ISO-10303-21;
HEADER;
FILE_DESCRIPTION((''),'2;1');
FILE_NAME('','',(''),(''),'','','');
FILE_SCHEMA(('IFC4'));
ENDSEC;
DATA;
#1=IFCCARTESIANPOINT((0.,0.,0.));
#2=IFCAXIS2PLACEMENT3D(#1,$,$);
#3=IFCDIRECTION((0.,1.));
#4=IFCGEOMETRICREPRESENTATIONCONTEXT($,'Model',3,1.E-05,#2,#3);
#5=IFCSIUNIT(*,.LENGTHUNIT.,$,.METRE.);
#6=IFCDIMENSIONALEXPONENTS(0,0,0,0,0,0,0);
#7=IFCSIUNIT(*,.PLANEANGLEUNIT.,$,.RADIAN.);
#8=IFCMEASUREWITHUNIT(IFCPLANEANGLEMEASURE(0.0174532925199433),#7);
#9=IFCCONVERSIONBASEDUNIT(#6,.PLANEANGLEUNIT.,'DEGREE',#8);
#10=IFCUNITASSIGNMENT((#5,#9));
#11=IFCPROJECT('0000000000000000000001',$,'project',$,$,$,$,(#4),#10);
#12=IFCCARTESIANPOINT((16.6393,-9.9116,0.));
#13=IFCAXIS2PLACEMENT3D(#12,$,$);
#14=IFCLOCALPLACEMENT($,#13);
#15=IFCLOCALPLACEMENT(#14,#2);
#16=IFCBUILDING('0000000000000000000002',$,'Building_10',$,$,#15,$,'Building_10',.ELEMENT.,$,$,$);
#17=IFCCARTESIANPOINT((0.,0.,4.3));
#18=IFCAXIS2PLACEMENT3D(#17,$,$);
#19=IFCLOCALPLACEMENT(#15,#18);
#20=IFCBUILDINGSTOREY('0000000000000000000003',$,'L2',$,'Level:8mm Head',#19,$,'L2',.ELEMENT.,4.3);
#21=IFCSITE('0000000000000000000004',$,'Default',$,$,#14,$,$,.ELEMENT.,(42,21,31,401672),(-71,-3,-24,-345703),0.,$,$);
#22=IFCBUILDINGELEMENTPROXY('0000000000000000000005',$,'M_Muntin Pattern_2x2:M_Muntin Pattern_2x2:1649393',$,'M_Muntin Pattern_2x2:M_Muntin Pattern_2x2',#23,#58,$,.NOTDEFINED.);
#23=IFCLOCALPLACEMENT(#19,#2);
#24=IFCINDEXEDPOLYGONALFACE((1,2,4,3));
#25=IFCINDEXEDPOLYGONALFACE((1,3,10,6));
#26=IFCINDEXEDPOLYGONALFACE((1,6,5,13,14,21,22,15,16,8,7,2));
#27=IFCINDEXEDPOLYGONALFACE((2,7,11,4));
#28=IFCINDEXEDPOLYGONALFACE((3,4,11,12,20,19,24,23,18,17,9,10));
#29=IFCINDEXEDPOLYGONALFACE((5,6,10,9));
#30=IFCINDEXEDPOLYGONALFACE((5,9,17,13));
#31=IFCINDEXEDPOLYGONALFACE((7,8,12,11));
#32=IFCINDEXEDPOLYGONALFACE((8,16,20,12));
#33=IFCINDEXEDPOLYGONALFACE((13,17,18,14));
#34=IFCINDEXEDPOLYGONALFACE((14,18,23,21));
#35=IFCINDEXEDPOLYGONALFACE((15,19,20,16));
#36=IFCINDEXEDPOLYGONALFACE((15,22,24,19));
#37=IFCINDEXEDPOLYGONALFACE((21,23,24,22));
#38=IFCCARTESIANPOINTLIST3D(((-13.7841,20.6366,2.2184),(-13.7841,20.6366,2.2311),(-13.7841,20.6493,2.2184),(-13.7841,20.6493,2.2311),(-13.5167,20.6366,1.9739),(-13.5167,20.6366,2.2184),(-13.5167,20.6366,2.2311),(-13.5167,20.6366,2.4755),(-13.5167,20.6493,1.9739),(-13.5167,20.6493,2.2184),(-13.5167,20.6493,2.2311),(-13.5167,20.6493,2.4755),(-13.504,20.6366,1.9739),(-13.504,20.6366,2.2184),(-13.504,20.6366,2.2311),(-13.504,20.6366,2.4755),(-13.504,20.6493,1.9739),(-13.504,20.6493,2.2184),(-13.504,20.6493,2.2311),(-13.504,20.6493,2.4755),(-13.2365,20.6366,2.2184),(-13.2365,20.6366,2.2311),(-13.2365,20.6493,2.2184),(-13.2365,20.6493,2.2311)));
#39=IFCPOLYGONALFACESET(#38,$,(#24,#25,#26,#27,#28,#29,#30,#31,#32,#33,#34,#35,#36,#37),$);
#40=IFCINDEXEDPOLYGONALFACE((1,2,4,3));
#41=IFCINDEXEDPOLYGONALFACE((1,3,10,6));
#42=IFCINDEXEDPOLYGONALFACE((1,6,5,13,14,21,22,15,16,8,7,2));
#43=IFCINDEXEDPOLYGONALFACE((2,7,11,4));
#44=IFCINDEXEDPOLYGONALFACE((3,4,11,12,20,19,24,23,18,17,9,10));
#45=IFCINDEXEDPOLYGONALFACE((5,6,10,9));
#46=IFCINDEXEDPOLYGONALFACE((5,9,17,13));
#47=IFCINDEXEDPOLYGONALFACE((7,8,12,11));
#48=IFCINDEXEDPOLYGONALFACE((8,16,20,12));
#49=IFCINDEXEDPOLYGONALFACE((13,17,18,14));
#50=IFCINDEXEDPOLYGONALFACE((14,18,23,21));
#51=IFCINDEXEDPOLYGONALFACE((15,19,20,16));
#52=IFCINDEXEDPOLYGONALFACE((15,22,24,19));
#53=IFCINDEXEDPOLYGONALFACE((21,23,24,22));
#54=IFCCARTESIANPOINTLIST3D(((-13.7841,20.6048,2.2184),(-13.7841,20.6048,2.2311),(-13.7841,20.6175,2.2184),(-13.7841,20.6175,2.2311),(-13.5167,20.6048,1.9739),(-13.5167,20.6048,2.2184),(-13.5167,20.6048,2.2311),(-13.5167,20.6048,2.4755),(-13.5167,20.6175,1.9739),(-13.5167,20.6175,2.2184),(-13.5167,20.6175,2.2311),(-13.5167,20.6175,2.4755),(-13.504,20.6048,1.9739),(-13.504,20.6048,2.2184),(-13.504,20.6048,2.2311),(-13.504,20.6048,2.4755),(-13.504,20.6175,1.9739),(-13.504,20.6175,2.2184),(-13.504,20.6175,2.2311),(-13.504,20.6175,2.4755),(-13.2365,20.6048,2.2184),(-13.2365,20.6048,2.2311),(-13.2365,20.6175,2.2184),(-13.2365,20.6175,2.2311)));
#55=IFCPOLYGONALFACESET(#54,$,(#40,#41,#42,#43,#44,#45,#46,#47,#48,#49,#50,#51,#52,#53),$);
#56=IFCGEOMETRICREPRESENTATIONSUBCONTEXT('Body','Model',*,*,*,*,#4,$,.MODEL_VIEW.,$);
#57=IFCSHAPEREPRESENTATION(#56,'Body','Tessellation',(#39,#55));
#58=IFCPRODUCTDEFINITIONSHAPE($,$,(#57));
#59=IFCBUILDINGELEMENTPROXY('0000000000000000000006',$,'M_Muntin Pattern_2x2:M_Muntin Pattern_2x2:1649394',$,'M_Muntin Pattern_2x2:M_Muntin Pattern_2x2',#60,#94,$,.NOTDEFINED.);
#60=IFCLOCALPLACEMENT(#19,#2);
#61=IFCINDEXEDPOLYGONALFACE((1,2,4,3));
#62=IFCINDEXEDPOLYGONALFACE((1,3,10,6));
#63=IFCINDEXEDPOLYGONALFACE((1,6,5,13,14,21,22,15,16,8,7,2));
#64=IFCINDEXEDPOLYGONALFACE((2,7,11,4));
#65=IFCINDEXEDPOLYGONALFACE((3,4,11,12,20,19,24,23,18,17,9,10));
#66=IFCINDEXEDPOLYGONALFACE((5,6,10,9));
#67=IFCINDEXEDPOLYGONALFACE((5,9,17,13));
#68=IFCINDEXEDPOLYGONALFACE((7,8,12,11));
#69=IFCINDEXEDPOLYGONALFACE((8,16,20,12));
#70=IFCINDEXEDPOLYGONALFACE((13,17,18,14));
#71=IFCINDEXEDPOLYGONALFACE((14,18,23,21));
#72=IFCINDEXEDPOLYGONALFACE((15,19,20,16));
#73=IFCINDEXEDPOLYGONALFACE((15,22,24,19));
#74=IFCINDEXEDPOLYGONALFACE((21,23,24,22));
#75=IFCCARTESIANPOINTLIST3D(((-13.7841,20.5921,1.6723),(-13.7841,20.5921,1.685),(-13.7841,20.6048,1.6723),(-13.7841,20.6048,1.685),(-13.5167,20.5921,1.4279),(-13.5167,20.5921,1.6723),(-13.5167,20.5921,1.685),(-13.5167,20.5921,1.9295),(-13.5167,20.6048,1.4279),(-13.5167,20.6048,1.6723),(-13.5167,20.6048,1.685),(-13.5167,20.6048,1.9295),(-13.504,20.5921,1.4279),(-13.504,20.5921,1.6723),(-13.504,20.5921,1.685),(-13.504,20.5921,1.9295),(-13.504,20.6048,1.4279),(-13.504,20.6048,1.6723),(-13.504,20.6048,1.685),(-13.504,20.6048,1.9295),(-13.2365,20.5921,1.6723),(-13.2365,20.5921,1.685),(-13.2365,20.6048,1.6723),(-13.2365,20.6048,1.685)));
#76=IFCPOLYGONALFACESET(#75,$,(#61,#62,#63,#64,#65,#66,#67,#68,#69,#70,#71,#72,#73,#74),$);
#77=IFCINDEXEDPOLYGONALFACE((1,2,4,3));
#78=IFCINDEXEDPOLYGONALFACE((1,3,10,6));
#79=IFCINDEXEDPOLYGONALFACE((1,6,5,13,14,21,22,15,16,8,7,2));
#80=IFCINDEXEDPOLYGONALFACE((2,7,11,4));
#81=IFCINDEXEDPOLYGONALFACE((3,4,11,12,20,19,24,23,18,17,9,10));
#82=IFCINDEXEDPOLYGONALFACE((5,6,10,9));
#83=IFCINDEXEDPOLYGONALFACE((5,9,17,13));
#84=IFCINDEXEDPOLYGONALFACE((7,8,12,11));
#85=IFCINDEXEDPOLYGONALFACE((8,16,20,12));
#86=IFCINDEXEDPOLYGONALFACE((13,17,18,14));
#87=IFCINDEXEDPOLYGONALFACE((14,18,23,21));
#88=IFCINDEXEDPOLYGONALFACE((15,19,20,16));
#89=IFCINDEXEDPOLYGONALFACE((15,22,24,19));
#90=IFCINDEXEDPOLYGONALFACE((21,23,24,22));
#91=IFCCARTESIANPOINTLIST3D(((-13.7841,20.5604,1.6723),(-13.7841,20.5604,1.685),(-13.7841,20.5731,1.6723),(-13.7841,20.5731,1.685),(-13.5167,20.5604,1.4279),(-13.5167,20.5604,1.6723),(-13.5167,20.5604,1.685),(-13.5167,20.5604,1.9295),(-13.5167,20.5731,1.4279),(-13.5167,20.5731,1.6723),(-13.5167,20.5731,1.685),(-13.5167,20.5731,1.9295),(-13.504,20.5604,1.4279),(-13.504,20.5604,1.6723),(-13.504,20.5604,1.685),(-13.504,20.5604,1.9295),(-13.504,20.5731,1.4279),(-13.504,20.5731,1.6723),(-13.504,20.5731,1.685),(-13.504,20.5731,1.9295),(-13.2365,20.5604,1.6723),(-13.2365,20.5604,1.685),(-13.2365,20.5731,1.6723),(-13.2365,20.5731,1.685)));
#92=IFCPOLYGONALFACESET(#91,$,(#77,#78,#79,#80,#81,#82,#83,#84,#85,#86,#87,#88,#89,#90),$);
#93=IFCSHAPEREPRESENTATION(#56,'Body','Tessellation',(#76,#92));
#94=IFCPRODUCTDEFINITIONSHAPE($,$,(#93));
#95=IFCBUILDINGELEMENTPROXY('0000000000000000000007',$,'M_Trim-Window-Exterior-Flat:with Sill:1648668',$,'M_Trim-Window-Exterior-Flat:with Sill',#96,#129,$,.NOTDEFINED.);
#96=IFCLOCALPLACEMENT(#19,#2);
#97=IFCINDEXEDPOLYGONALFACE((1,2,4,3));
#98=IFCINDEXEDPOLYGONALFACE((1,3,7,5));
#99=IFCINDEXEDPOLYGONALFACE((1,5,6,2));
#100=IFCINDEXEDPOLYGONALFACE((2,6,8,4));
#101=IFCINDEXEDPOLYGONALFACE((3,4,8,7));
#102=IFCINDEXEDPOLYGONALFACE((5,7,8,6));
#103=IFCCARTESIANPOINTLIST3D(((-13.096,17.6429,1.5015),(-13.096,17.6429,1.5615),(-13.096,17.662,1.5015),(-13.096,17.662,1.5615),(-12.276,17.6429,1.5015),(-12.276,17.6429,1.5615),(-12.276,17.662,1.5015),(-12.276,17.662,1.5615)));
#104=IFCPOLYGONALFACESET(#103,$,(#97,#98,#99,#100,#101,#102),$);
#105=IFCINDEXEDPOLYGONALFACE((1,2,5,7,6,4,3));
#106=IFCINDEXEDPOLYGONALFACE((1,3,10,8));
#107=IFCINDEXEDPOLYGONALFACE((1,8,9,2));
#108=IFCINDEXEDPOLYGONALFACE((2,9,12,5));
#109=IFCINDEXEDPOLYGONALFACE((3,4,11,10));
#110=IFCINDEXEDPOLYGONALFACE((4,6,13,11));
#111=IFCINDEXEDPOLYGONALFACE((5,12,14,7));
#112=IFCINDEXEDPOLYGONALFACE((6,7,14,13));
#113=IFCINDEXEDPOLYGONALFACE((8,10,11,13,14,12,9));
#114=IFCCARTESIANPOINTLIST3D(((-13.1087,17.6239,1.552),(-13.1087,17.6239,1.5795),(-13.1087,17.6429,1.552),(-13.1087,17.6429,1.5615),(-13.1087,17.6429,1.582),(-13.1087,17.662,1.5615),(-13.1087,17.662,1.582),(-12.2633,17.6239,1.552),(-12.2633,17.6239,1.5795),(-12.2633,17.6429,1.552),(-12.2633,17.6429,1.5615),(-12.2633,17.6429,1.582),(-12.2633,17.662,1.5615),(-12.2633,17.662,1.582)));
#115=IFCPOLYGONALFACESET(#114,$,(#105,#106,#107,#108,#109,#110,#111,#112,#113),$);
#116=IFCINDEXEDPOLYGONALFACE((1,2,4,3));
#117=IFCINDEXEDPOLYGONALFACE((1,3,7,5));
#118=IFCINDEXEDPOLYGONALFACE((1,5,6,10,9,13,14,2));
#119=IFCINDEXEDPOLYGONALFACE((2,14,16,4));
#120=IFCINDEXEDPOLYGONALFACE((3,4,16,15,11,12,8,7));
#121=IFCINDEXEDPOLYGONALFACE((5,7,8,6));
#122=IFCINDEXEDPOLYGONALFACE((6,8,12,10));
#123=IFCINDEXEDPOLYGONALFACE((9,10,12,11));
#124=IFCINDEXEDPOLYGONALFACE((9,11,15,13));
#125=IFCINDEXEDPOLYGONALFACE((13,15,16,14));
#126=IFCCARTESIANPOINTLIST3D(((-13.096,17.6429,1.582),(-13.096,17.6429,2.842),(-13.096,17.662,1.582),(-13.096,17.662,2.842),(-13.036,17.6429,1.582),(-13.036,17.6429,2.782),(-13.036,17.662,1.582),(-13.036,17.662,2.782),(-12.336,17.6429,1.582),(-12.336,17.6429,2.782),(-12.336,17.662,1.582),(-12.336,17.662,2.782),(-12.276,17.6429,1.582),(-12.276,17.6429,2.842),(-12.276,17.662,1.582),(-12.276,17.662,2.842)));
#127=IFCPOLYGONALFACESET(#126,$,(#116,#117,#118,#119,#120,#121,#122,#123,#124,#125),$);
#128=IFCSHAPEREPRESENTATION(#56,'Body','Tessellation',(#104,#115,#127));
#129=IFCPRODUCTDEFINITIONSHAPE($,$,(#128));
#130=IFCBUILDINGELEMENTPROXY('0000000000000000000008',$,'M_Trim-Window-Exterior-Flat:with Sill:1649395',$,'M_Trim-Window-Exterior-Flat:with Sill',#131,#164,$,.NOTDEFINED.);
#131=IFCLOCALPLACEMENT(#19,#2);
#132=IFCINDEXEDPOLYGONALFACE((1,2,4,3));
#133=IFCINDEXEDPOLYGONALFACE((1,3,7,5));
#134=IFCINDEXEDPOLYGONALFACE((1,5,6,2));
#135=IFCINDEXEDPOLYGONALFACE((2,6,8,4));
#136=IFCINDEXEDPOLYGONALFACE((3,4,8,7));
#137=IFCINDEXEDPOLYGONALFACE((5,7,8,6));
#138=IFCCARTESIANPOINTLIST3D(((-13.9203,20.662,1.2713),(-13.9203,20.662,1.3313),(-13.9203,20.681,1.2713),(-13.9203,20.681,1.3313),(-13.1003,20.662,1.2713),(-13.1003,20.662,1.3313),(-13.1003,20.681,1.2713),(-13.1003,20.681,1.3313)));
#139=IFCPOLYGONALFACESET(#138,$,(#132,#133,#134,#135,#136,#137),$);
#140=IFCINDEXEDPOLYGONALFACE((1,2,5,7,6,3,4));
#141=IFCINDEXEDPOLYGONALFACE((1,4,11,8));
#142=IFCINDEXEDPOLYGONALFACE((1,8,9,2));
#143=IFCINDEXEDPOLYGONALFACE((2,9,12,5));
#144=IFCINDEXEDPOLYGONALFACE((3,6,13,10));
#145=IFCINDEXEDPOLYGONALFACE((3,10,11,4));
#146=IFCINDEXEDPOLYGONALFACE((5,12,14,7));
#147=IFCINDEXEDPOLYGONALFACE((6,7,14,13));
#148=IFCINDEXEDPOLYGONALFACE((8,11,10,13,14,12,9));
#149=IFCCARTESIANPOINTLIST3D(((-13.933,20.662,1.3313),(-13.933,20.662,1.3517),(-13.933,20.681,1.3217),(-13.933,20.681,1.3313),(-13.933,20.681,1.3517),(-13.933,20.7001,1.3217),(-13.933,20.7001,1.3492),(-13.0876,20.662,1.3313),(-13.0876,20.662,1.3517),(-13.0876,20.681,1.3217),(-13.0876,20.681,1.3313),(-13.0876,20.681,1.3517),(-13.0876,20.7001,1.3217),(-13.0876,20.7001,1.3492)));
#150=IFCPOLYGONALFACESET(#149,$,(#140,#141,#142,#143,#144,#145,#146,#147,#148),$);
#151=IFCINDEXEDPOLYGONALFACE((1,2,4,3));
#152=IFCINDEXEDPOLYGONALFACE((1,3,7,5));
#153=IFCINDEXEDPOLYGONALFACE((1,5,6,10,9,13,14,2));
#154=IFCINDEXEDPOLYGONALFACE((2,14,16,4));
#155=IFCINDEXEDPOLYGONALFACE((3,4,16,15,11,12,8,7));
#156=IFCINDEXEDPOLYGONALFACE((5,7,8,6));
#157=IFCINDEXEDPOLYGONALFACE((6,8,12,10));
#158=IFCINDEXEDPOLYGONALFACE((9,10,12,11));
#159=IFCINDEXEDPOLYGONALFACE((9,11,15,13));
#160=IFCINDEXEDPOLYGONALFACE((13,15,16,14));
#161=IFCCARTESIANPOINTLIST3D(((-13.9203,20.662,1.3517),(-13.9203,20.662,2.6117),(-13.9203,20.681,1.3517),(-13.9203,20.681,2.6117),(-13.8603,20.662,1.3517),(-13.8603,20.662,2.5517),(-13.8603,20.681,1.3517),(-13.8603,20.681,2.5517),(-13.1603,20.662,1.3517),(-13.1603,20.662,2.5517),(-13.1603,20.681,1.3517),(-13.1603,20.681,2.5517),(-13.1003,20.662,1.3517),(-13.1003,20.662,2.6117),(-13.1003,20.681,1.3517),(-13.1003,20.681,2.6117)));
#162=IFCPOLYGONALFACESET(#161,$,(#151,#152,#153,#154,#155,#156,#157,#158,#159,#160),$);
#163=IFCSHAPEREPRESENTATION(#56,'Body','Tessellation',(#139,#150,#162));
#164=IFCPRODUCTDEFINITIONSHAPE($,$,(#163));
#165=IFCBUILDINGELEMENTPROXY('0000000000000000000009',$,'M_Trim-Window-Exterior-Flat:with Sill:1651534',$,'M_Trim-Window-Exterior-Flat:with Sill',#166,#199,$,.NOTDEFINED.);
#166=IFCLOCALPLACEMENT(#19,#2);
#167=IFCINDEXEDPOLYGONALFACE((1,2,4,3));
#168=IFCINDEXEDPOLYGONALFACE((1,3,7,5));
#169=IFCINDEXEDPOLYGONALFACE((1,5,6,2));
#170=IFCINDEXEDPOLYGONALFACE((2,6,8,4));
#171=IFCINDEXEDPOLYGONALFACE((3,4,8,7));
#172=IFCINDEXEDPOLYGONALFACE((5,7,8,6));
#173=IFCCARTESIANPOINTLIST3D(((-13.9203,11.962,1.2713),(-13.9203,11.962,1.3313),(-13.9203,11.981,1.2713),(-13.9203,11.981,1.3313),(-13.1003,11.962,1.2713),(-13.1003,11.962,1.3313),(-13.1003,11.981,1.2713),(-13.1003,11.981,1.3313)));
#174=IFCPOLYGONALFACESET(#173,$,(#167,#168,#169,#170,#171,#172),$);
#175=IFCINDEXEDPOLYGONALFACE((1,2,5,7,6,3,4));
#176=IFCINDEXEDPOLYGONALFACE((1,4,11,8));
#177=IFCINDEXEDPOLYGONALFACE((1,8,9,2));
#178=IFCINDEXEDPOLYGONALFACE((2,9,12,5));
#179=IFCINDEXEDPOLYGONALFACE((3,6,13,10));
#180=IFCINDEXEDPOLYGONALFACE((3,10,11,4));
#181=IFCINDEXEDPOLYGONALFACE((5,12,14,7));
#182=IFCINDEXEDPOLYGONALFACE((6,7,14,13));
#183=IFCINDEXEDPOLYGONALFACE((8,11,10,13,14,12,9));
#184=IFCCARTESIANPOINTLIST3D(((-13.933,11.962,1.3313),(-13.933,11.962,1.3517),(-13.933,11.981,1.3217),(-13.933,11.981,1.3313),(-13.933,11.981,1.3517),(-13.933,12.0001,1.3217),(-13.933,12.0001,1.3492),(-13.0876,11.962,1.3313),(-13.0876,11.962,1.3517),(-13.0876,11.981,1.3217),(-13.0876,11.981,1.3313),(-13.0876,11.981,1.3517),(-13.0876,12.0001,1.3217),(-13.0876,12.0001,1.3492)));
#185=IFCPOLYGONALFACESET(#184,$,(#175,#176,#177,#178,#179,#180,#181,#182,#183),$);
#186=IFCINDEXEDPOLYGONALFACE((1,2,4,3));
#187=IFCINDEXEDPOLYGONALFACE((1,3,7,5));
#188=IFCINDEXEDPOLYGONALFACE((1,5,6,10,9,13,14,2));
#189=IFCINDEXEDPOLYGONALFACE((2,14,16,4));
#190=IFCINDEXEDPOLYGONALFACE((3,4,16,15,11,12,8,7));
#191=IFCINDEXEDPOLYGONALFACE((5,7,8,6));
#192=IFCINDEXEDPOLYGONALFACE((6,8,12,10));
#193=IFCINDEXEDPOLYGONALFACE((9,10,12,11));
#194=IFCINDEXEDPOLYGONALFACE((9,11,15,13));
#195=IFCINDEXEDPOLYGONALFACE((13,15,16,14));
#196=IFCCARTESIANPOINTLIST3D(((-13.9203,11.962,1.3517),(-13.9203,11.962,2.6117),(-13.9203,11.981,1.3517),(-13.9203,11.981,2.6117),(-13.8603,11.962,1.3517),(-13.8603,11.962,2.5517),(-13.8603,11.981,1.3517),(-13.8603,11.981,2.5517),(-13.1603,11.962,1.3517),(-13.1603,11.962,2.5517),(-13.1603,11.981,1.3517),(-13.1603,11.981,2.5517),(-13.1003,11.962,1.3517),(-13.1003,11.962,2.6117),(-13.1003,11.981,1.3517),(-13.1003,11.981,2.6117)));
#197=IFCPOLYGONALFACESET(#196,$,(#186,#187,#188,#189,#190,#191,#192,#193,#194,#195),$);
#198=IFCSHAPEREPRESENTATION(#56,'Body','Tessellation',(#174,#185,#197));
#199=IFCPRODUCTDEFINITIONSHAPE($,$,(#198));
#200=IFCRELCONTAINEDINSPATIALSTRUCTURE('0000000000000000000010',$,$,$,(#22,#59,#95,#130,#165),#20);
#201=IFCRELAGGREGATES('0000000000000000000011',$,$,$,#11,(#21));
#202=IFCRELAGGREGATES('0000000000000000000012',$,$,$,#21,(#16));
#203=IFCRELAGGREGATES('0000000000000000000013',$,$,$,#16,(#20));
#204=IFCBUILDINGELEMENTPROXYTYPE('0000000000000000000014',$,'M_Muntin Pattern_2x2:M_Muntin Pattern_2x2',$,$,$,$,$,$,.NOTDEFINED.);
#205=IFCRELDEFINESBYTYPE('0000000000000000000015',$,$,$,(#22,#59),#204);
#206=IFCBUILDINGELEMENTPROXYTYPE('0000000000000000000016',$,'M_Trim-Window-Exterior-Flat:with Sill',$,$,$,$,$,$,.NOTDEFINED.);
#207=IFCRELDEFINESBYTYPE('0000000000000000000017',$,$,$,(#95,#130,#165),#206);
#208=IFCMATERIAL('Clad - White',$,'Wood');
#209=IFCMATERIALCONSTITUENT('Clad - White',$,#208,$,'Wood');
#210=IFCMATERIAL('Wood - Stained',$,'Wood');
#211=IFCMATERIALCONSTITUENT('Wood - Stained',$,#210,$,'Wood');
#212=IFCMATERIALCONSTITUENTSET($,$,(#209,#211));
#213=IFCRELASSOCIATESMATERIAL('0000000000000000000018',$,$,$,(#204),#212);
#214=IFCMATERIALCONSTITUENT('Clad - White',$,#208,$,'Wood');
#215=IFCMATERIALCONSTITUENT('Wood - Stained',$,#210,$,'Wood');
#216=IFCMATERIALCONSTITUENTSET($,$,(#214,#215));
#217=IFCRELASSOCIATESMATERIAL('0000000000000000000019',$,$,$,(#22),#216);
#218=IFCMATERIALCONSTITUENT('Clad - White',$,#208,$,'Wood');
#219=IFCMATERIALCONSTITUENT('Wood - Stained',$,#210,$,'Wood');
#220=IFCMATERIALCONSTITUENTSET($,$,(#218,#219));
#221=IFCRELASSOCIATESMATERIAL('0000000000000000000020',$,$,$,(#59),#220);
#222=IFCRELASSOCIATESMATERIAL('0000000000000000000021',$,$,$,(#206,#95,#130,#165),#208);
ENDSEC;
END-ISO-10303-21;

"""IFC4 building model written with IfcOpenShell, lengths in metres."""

from ifc_helpers import new_model, entity, si_unit, converted_unit, direction, frame, origin, place, context, subcontext, project, spatial, indexed_curve, outline, extrude, source, transform, mapped, material, constituent, constituent_set, type_object, type_shapes, element, save


model = new_model("IFC4")

# Units and contexts
model_context = context("Model", 3, precision=1e-05, world=origin(), true_north=direction((0.0, 1.0)))
body_context = subcontext(model_context, "Body", "Model", "MODEL_VIEW")
ifc_project = project(units=[si_unit("LENGTHUNIT", "METRE"), converted_unit("PLANEANGLEUNIT", "DEGREE", entity("IfcPlaneAngleMeasure", 0.0174532925199433), si_unit("PLANEANGLEUNIT", "RADIAN"), dimensions=[0, 0, 0, 0, 0, 0, 0])], contexts=[model_context])

# Site, building, storey
site_placement = place(None, frame((16.6393, -9.9116, 0.0)))
site = spatial("IfcSite", under=ifc_project, at=site_placement, Name="Default", CompositionType="ELEMENT", RefLatitude=(42, 21, 31, 401672), RefLongitude=(-71, -3, -24, -345703), RefElevation=0.0)
building_placement = place(site_placement, origin())
building = spatial("IfcBuilding", under=site, at=building_placement, Name="Building_10", LongName="Building_10", CompositionType="ELEMENT")
storey_placement = place(building_placement, frame((0.0, 0.0, 4.3)))
storey = spatial("IfcBuildingStorey", under=building, at=storey_placement, Name="L2", ObjectType="Level:8mm Head", LongName="L2", CompositionType="ELEMENT", Elevation=4.3)

# Building element proxies
ifc_material_1 = material(Name="Clad - White", Category="Wood")
ifc_material_2 = material(Name="Wood - Stained", Category="Wood")
ifc_constituent_1 = constituent(ifc_material_1, Name="Clad - White", Category="Wood")
ifc_constituent_2 = constituent(ifc_material_2, Name="Wood - Stained", Category="Wood")
ifc_constituent_set_1 = constituent_set(constituents=[ifc_constituent_1, ifc_constituent_2])
building_element_proxy_type_1 = type_object("IfcBuildingElementProxyType", Name="M_Muntin Pattern_2x2:M_Muntin Pattern_2x2", PredefinedType="NOTDEFINED", material=ifc_constituent_set_1)
shared_shape_1 = source(origin(), body_context, "Body", "SweptSolid", [
    extrude(outline(indexed_curve([(0.0064, -0.0064), (0.2508, -0.0064), (0.2508, 0.0063), (0.0064, 0.0063), (0.0064, 0.2738), (-0.0063, 0.2738), (-0.0063, 0.0063), (-0.2508, 0.0063), (-0.2508, -0.0064), (-0.0063, -0.0064), (-0.0063, -0.2738), (0.0064, -0.2738), (0.0064, -0.0064)], self_intersect=False)), frame((0.0, 0.0095, 0.2508), z_axis=(0.0, 1.0, 0.0), x_axis=(0.0, 0.0, 1.0)), (0.0, 0.0, 1.0), 0.0127),
    extrude(outline(indexed_curve([(0.0064, -0.0064), (0.2508, -0.0064), (0.2508, 0.0063), (0.0064, 0.0063), (0.0064, 0.2738), (-0.0063, 0.2738), (-0.0063, 0.0063), (-0.2508, 0.0063), (-0.2508, -0.0064), (-0.0063, -0.0064), (-0.0063, -0.2738), (0.0064, -0.2738), (0.0064, -0.0064)], self_intersect=False)), frame((0.0, -0.0222, 0.2508), z_axis=(0.0, 1.0, 0.0), x_axis=(0.0, 0.0, 1.0)), (0.0, 0.0, 1.0), 0.0127),
])
type_shapes(building_element_proxy_type_1, [shared_shape_1])
ifc_constituent_3 = constituent(ifc_material_1, Name="Clad - White", Category="Wood")
ifc_constituent_4 = constituent(ifc_material_2, Name="Wood - Stained", Category="Wood")
ifc_constituent_set_2 = constituent_set(constituents=[ifc_constituent_3, ifc_constituent_4])
proxy_1_placement = place(storey_placement, frame((-13.5103, 20.627, 1.9739)))
element("IfcBuildingElementProxy", 1, at=proxy_1_placement, inside=storey, type_object=building_element_proxy_type_1, material=ifc_constituent_set_2, Name="M_Muntin Pattern_2x2:M_Muntin Pattern_2x2:1649393", ObjectType="M_Muntin Pattern_2x2:M_Muntin Pattern_2x2", PredefinedType="NOTDEFINED", context=body_context, shape_type="MappedRepresentation", body=[
    mapped(shared_shape_1, transform((0.0, 0.0, 0.0), scale=1.0)),
])
ifc_constituent_5 = constituent(ifc_material_1, Name="Clad - White", Category="Wood")
ifc_constituent_6 = constituent(ifc_material_2, Name="Wood - Stained", Category="Wood")
ifc_constituent_set_3 = constituent_set(constituents=[ifc_constituent_5, ifc_constituent_6])
proxy_2_placement = place(storey_placement, frame((-13.5103, 20.5826, 1.4279)))
element("IfcBuildingElementProxy", 2, at=proxy_2_placement, inside=storey, type_object=building_element_proxy_type_1, material=ifc_constituent_set_3, Name="M_Muntin Pattern_2x2:M_Muntin Pattern_2x2:1649394", ObjectType="M_Muntin Pattern_2x2:M_Muntin Pattern_2x2", PredefinedType="NOTDEFINED", context=body_context, shape_type="MappedRepresentation", body=[
    mapped(shared_shape_1, transform((0.0, 0.0, 0.0), scale=1.0)),
])
building_element_proxy_type_2 = type_object("IfcBuildingElementProxyType", Name="M_Trim-Window-Exterior-Flat:with Sill", PredefinedType="NOTDEFINED", material=ifc_material_1)
shared_shape_2 = source(origin(), body_context, "Body", "SweptSolid", [
    extrude(outline(indexed_curve([(-0.41, -0.03), (0.41, -0.03), (0.41, 0.03), (-0.41, 0.03), (-0.41, -0.03)], self_intersect=False)), frame((0.0, -1.2504, 0.0), z_axis=(0.0, 0.0, 1.0), x_axis=(-1.0, 0.0, 0.0)), (0.0, 0.0, 1.0), 0.0191),
    extrude(outline(indexed_curve([(-0.019, -0.0152), (0.0, -0.0152), (0.0, -0.0057), (0.019, -0.0057), (0.019, 0.0148), (0.0, 0.0148), (-0.019, 0.0123), (-0.019, -0.0152)], self_intersect=False)), frame((-0.4227, -1.2148, 0.019), z_axis=(1.0, 0.0, 0.0), x_axis=(0.0, 0.0, -1.0)), (0.0, 0.0, 1.0), 0.8454),
    extrude(outline(indexed_curve([(-0.645, -0.41), (0.615, -0.41), (0.615, -0.35), (-0.585, -0.35), (-0.585, 0.35), (0.615, 0.35), (0.615, 0.41), (-0.645, 0.41), (-0.645, -0.41)], self_intersect=False)), frame((0.0, -0.585, 0.0), z_axis=(0.0, 0.0, 1.0), x_axis=(0.0, -1.0, 0.0)), (0.0, 0.0, 1.0), 0.0191),
])
type_shapes(building_element_proxy_type_2, [shared_shape_2])
for number, where, z_axis, x_axis, name in (
    (3, (-12.686, 17.662, 2.782), (0.0, -1.0, 0.0), (1.0, 0.0, 0.0), "M_Trim-Window-Exterior-Flat:with Sill:1648668"),
    (4, (-13.5103, 20.662, 2.5517), (0.0, 1.0, 0.0), (-1.0, 0.0, 0.0), "M_Trim-Window-Exterior-Flat:with Sill:1649395"),
    (5, (-13.5103, 11.962, 2.5517), (0.0, 1.0, 0.0), (-1.0, 0.0, 0.0), "M_Trim-Window-Exterior-Flat:with Sill:1651534"),
):
    element("IfcBuildingElementProxy", number, at=place(storey_placement, frame(where, z_axis=z_axis, x_axis=x_axis)), inside=storey, type_object=building_element_proxy_type_2, material=ifc_material_1, Name=name, ObjectType="M_Trim-Window-Exterior-Flat:with Sill", PredefinedType="NOTDEFINED", context=body_context, shape_type="MappedRepresentation", body=[
        mapped(shared_shape_2, transform((0.0, 0.0, 0.0), scale=1.0)),
    ])

save(model, "model.ifc")
